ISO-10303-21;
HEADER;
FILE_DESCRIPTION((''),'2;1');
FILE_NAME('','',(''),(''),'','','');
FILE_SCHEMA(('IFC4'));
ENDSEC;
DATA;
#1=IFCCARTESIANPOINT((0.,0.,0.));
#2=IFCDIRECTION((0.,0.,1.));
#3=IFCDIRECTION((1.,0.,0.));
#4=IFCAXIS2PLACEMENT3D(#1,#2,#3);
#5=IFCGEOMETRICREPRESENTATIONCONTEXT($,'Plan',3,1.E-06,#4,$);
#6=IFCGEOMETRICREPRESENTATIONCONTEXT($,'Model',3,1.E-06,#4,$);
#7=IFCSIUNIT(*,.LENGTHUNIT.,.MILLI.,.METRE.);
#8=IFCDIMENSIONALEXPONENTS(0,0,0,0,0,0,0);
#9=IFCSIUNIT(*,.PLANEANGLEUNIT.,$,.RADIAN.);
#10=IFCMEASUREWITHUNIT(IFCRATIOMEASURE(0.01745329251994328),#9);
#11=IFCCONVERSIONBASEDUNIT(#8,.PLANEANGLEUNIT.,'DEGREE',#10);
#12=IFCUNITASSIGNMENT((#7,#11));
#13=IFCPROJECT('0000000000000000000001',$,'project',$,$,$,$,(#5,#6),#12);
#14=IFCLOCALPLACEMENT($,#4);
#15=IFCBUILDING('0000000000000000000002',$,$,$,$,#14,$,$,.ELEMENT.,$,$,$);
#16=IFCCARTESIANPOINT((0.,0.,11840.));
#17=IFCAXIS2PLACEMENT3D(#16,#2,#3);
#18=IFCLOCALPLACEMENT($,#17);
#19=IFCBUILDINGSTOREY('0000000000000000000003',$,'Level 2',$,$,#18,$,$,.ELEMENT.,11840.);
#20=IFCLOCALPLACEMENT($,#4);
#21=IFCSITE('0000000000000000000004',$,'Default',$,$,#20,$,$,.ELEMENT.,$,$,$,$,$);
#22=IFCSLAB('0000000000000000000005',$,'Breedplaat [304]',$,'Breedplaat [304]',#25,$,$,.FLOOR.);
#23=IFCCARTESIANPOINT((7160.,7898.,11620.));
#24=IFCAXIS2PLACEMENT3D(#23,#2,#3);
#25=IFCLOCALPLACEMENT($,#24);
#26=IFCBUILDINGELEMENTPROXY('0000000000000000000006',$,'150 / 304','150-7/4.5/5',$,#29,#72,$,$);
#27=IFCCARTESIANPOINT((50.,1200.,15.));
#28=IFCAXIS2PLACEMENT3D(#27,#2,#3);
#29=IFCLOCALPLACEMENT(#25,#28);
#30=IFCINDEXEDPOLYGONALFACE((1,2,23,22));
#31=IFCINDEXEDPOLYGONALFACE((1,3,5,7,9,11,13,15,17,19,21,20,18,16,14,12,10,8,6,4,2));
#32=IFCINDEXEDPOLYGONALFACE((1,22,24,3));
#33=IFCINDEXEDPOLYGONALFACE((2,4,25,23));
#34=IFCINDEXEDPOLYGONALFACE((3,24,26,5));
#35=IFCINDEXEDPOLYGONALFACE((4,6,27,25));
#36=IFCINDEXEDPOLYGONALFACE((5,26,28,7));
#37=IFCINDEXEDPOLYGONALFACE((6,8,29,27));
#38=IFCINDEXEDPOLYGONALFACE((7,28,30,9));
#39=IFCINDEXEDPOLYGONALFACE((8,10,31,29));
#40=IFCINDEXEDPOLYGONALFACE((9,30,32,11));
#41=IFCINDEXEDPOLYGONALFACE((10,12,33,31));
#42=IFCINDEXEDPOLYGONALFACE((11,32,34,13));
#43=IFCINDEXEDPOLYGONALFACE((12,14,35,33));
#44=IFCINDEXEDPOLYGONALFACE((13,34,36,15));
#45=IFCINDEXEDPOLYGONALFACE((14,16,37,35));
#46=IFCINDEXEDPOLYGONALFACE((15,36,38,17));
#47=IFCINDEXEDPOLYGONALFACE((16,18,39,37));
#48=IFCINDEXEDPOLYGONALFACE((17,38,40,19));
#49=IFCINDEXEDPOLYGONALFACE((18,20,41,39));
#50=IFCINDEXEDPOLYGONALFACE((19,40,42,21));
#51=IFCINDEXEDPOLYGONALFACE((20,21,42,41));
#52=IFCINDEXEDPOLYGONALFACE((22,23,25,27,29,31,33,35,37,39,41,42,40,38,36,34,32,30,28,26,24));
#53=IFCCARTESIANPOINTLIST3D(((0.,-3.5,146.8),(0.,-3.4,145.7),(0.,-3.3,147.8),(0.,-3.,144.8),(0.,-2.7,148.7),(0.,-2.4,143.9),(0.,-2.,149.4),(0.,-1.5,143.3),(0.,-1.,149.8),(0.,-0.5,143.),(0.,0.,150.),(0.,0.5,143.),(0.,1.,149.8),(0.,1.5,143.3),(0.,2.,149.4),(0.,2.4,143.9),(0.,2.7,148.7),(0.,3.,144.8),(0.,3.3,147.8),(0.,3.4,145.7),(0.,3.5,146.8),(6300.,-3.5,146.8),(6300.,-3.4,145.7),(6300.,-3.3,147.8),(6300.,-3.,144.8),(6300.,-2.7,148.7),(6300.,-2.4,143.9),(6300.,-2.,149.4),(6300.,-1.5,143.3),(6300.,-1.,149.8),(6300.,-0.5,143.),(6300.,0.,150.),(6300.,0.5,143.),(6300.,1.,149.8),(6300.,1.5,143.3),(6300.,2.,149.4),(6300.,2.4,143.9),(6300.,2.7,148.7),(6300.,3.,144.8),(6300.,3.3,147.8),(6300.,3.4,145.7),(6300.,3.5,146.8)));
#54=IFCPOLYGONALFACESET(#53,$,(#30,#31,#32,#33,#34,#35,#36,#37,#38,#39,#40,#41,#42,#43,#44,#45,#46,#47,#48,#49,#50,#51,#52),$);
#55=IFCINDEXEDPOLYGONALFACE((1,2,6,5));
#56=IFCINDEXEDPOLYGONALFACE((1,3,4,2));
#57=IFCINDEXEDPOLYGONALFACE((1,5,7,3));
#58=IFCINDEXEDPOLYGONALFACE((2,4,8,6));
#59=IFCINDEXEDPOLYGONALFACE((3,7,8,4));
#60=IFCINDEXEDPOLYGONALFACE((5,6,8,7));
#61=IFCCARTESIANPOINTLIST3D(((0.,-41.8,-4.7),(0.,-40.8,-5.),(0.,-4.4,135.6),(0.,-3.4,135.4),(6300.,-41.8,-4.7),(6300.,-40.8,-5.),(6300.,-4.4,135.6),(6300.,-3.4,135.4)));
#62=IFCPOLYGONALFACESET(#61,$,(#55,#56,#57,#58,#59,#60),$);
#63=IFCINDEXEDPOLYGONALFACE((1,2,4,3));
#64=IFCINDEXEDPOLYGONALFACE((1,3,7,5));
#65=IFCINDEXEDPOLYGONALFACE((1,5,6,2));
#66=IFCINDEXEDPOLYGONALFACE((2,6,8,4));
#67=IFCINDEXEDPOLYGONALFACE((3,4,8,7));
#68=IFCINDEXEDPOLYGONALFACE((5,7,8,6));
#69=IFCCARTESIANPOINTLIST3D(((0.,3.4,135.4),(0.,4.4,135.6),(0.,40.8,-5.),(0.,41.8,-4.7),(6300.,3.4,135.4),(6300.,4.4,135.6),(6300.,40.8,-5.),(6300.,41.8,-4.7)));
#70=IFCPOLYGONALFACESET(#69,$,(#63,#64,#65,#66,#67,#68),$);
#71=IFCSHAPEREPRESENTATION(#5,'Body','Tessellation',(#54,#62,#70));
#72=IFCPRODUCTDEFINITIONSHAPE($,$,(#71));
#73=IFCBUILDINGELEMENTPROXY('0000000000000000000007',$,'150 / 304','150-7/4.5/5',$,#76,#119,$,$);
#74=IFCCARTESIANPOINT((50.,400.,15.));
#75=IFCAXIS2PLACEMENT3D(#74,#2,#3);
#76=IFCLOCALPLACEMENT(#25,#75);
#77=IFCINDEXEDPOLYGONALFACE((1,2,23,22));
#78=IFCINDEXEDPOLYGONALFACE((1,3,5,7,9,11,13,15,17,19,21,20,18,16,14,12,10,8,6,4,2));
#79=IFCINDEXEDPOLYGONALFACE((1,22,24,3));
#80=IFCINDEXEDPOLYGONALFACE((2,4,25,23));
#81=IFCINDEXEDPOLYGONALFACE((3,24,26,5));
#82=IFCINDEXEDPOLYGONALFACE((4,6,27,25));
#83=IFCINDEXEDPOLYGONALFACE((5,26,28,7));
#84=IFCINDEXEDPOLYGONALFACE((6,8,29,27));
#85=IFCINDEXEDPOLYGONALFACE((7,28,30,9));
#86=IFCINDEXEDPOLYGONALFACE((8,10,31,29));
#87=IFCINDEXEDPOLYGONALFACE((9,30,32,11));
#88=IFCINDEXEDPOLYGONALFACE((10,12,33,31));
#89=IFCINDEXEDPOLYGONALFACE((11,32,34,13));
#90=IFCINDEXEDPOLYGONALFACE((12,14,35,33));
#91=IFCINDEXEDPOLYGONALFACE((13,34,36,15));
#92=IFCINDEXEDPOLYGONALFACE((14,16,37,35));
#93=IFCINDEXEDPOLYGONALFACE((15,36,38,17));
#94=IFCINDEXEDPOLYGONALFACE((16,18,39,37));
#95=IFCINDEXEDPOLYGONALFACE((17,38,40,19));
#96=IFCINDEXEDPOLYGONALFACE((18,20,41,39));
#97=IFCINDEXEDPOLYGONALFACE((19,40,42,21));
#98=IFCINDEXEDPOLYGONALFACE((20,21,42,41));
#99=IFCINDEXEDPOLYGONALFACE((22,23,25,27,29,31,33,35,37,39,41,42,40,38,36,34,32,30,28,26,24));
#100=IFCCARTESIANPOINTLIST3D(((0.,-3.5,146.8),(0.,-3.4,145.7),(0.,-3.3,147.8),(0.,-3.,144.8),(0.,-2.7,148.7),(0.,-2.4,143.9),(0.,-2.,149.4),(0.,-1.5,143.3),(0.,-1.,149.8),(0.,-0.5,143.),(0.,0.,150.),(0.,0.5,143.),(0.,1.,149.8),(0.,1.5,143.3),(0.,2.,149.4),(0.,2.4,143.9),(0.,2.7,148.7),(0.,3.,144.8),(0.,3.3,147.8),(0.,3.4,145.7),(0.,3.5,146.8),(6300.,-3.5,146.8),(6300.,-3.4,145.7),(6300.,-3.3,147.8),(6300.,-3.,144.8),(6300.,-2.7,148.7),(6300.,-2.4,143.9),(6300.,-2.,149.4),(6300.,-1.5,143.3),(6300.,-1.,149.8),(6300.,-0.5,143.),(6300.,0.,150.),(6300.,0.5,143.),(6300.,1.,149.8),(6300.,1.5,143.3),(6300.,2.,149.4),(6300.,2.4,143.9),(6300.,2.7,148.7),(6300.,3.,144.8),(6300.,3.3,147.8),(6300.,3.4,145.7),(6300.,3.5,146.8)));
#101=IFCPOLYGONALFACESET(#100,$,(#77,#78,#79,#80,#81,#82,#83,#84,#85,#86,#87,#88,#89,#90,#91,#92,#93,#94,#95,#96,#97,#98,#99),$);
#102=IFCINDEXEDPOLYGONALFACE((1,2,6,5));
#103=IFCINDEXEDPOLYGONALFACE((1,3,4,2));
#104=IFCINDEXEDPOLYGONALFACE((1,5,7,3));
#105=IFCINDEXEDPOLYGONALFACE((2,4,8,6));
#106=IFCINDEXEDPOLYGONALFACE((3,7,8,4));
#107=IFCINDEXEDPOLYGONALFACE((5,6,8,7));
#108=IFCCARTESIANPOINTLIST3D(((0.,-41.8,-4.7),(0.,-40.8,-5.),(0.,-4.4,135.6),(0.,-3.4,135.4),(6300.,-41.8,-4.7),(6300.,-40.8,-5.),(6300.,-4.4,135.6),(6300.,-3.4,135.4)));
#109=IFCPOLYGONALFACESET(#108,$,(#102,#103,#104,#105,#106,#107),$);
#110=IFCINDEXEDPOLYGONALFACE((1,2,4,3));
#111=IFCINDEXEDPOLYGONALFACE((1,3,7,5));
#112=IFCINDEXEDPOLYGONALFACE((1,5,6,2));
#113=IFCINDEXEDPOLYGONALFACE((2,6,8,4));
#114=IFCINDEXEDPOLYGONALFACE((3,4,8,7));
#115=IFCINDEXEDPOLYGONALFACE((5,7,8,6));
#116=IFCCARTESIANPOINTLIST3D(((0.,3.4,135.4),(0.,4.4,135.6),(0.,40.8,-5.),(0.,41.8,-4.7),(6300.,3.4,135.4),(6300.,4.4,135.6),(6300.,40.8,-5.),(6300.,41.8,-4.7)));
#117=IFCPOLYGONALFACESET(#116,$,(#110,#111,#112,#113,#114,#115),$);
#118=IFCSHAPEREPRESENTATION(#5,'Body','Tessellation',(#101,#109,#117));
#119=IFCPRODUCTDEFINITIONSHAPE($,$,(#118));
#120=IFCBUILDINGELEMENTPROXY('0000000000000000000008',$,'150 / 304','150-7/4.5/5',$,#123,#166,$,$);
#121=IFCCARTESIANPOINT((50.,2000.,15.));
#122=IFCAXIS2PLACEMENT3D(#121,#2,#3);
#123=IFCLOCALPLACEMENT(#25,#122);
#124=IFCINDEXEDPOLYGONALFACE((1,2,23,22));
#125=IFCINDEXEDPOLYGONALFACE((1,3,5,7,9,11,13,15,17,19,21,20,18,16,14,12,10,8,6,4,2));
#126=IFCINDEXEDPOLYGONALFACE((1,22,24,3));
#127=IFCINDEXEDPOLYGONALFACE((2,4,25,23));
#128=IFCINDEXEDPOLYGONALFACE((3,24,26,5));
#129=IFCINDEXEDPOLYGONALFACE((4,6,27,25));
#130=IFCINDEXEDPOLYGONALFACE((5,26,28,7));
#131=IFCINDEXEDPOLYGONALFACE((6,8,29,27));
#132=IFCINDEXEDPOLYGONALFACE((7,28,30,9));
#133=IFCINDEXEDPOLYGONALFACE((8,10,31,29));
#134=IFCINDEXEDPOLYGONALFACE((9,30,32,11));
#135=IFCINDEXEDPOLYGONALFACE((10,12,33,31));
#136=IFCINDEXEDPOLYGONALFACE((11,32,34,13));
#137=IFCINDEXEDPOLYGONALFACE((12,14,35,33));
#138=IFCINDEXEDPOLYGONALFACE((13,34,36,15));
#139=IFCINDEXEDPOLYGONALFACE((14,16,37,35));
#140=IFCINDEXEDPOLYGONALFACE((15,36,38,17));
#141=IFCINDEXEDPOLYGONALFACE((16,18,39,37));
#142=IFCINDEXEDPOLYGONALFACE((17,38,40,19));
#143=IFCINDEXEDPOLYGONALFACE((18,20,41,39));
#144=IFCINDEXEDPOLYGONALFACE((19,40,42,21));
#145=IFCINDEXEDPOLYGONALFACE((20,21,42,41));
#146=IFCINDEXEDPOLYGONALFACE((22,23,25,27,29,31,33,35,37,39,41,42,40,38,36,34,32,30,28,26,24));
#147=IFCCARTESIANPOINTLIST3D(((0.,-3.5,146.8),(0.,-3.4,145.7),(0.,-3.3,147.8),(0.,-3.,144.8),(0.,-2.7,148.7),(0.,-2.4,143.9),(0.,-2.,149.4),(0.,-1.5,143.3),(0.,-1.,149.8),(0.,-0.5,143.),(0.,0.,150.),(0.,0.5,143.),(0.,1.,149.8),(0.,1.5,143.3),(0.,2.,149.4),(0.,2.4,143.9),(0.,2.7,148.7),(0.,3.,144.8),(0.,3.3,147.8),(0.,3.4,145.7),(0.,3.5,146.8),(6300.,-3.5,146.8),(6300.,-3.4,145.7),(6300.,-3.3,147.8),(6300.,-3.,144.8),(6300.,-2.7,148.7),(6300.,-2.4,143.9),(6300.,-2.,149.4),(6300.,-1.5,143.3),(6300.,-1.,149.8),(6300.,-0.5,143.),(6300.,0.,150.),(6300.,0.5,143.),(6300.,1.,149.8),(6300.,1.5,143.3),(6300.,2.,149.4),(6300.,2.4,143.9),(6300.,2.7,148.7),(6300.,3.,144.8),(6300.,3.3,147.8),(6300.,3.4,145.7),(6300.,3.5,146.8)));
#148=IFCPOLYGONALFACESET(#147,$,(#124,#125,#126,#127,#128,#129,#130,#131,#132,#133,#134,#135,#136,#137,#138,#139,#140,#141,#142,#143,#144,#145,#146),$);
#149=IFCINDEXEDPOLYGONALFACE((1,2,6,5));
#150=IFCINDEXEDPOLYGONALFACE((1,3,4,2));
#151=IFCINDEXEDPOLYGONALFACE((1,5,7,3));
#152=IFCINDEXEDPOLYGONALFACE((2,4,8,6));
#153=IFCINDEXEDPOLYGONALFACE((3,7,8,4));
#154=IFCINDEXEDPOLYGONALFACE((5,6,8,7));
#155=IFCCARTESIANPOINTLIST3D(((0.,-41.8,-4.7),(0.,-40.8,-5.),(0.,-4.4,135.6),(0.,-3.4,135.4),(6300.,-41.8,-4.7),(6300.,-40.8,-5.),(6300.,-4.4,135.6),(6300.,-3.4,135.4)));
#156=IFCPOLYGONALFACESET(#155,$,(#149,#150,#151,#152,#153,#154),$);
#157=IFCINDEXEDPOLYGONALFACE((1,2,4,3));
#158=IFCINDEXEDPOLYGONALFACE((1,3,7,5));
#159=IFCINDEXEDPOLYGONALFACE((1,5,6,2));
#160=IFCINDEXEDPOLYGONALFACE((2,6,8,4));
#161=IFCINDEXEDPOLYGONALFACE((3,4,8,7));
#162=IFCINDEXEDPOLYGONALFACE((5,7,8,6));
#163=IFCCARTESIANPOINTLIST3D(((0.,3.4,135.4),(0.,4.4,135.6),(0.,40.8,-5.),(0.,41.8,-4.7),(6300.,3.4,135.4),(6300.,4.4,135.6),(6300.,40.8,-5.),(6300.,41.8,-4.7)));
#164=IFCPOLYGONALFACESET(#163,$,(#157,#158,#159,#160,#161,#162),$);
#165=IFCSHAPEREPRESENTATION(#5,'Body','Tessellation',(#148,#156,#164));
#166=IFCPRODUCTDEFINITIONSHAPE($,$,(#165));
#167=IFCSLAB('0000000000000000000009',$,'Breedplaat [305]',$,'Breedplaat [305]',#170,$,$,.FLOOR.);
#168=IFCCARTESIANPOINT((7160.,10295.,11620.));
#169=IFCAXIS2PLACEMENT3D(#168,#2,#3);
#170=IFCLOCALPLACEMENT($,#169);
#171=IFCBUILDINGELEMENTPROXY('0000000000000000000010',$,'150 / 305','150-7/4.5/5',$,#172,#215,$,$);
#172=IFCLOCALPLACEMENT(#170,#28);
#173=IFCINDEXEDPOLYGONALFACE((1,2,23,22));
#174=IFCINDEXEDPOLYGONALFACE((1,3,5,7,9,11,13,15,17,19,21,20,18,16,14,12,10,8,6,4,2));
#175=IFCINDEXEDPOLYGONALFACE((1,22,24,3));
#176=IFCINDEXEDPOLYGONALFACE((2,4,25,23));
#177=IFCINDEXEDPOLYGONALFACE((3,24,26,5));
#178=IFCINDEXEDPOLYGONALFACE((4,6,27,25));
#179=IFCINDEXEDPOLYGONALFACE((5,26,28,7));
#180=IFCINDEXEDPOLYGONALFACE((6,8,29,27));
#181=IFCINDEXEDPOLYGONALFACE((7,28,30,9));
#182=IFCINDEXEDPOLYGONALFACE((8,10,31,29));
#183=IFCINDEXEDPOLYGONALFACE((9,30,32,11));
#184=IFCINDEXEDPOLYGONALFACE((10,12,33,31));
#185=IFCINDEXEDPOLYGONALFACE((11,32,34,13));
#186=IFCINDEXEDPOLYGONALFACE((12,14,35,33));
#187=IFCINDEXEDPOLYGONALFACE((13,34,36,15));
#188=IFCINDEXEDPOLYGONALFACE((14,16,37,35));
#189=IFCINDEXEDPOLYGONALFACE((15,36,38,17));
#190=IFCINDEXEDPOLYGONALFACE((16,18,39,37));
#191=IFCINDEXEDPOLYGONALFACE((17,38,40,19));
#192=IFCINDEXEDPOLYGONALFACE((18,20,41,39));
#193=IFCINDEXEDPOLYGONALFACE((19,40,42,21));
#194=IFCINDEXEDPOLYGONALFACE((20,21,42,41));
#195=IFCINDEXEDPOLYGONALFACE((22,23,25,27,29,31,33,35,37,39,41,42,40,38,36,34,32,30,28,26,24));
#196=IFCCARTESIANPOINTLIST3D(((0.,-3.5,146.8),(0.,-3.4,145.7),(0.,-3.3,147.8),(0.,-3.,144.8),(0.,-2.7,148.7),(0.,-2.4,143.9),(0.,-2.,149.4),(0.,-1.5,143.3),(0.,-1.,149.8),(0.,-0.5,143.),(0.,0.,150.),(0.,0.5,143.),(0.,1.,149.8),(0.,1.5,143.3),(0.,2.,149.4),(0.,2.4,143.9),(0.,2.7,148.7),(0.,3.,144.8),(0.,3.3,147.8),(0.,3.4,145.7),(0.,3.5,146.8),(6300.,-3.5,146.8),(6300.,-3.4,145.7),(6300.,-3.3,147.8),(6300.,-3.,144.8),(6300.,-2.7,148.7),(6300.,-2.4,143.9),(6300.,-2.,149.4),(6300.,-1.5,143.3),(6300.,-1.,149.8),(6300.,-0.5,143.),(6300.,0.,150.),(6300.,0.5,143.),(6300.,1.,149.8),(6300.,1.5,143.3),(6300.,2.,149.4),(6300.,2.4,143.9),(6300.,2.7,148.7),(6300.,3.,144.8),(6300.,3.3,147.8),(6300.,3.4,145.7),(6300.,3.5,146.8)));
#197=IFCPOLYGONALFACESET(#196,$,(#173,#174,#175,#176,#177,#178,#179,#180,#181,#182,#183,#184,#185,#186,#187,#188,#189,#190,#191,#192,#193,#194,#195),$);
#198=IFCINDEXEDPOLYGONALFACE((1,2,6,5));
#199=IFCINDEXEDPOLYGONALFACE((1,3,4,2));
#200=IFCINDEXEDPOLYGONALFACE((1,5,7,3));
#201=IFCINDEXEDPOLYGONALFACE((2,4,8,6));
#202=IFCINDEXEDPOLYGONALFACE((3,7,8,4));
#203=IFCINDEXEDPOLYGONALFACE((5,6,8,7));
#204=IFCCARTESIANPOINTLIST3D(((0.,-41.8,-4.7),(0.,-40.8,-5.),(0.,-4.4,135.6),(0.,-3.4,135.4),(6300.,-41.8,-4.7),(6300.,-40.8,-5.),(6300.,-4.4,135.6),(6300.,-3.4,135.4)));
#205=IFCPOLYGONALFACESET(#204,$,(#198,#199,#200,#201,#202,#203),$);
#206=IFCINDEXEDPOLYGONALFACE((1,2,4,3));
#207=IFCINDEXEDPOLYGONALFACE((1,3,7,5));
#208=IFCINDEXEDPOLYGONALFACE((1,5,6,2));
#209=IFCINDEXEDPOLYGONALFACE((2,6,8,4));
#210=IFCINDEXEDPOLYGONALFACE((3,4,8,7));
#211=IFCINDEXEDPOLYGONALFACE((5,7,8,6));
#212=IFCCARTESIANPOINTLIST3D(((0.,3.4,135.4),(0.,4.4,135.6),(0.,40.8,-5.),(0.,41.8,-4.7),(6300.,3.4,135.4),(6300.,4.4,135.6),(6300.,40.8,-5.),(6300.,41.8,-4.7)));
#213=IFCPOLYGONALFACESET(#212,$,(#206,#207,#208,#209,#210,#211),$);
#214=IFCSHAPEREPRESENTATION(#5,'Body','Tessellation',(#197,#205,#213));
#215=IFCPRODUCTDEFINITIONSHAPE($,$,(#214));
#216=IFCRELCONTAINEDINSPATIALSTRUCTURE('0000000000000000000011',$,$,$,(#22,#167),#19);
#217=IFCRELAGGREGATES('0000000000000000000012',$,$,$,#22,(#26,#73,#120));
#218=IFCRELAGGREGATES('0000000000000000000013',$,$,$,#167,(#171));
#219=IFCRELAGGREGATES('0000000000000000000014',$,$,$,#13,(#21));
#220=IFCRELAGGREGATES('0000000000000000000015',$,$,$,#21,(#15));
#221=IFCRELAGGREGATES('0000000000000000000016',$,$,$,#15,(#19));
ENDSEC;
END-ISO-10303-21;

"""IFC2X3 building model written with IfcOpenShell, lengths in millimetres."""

from ifc_helpers import new_model, entity, si_unit, converted_unit, frame, origin_with_axes, origin_2d_with_axis, place, context, project, spatial, rectangle, circle, extrude, element, aggregate, save


model = new_model("IFC2X3")

# Units and contexts
plan_context = context("Plan", 3, precision=1e-06, world=origin_with_axes())
model_context = context("Model", 3, precision=1e-06, world=origin_with_axes())
ifc_project = project(units=[si_unit("LENGTHUNIT", "METRE", prefix="MILLI"), converted_unit("PLANEANGLEUNIT", "DEGREE", entity("IfcRatioMeasure", 0.01745329251994328), si_unit("PLANEANGLEUNIT", "RADIAN"), dimensions=[0, 0, 0, 0, 0, 0, 0])], contexts=[plan_context, model_context])

# Site, building, storey
site_placement = place(None, origin_with_axes())
site = spatial("IfcSite", under=ifc_project, at=site_placement, Name="Default", CompositionType="ELEMENT")
building_placement = place(None, origin_with_axes())
building = spatial("IfcBuilding", under=site, at=building_placement, CompositionType="ELEMENT")
storey_placement = place(None, frame((0.0, 0.0, 11840.0), z_axis=(0.0, 0.0, 1.0), x_axis=(1.0, 0.0, 0.0)))
storey = spatial("IfcBuildingStorey", under=building, at=storey_placement, Name="Level 2", CompositionType="ELEMENT", Elevation=11840.0)

# Slab, building element proxies
slab_1_placement = place(None, frame((7160.0, 7898.0, 11620.0), z_axis=(0.0, 0.0, 1.0), x_axis=(1.0, 0.0, 0.0)))
slab_1 = element("IfcSlab", 1, at=slab_1_placement, inside=storey, Name="Breedplaat [304]", ObjectType="Breedplaat [304]", PredefinedType="FLOOR")
proxy_1_placement = place(slab_1_placement, frame((50.0, 1200.0, 15.0), z_axis=(0.0, 0.0, 1.0), x_axis=(1.0, 0.0, 0.0)))
proxy_1 = element("IfcBuildingElementProxy", 2, at=proxy_1_placement, Name="150 / 304", Description="150-7/4.5/5", context=plan_context, shape_type="SweptSolid", body=[
    extrude(circle(Radius=3.5, at=origin_2d_with_axis()), frame((0.0, 0.0, 146.5), z_axis=(1.0, 0.0, 0.0), x_axis=(0.0, 0.0, 1.0)), (0.0, 0.0, 1.0), 6300.0),
    extrude(rectangle(XDim=145.2, YDim=1.0, at=origin_2d_with_axis()), frame((0.0, -22.6, 65.3), z_axis=(1.0, 0.0, 0.0), x_axis=(0.0, 0.257663, 0.966235)), (0.0, 0.0, 1.0), 6300.0),
    extrude(rectangle(XDim=145.2, YDim=1.0, at=origin_2d_with_axis()), frame((0.0, 22.6, 65.3), z_axis=(1.0, 0.0, 0.0), x_axis=(0.0, -0.257663, 0.966235)), (0.0, 0.0, 1.0), 6300.0),
])
proxy_2_placement = place(slab_1_placement, frame((50.0, 400.0, 15.0), z_axis=(0.0, 0.0, 1.0), x_axis=(1.0, 0.0, 0.0)))
proxy_2 = element("IfcBuildingElementProxy", 3, at=proxy_2_placement, Name="150 / 304", Description="150-7/4.5/5", context=plan_context, shape_type="SweptSolid", body=[
    extrude(circle(Radius=3.5, at=origin_2d_with_axis()), frame((0.0, 0.0, 146.5), z_axis=(1.0, 0.0, 0.0), x_axis=(0.0, 0.0, 1.0)), (0.0, 0.0, 1.0), 6300.0),
    extrude(rectangle(XDim=145.2, YDim=1.0, at=origin_2d_with_axis()), frame((0.0, -22.6, 65.3), z_axis=(1.0, 0.0, 0.0), x_axis=(0.0, 0.257663, 0.966235)), (0.0, 0.0, 1.0), 6300.0),
    extrude(rectangle(XDim=145.2, YDim=1.0, at=origin_2d_with_axis()), frame((0.0, 22.6, 65.3), z_axis=(1.0, 0.0, 0.0), x_axis=(0.0, -0.257663, 0.966235)), (0.0, 0.0, 1.0), 6300.0),
])
proxy_3_placement = place(slab_1_placement, frame((50.0, 2000.0, 15.0), z_axis=(0.0, 0.0, 1.0), x_axis=(1.0, 0.0, 0.0)))
proxy_3 = element("IfcBuildingElementProxy", 4, at=proxy_3_placement, Name="150 / 304", Description="150-7/4.5/5", context=plan_context, shape_type="SweptSolid", body=[
    extrude(circle(Radius=3.5, at=origin_2d_with_axis()), frame((0.0, 0.0, 146.5), z_axis=(1.0, 0.0, 0.0), x_axis=(0.0, 0.0, 1.0)), (0.0, 0.0, 1.0), 6300.0),
    extrude(rectangle(XDim=145.2, YDim=1.0, at=origin_2d_with_axis()), frame((0.0, -22.6, 65.3), z_axis=(1.0, 0.0, 0.0), x_axis=(0.0, 0.257663, 0.966235)), (0.0, 0.0, 1.0), 6300.0),
    extrude(rectangle(XDim=145.2, YDim=1.0, at=origin_2d_with_axis()), frame((0.0, 22.6, 65.3), z_axis=(1.0, 0.0, 0.0), x_axis=(0.0, -0.257663, 0.966235)), (0.0, 0.0, 1.0), 6300.0),
])
aggregate(slab_1, [proxy_1, proxy_2, proxy_3])

# Slab, building element proxy
slab_2_placement = place(None, frame((7160.0, 10295.0, 11620.0), z_axis=(0.0, 0.0, 1.0), x_axis=(1.0, 0.0, 0.0)))
slab_2 = element("IfcSlab", 5, at=slab_2_placement, inside=storey, Name="Breedplaat [305]", ObjectType="Breedplaat [305]", PredefinedType="FLOOR")
proxy_4_placement = place(slab_2_placement, frame((50.0, 1200.0, 15.0), z_axis=(0.0, 0.0, 1.0), x_axis=(1.0, 0.0, 0.0)))
proxy_4 = element("IfcBuildingElementProxy", 6, at=proxy_4_placement, Name="150 / 305", Description="150-7/4.5/5", context=plan_context, shape_type="SweptSolid", body=[
    extrude(circle(Radius=3.5, at=origin_2d_with_axis()), frame((0.0, 0.0, 146.5), z_axis=(1.0, 0.0, 0.0), x_axis=(0.0, 0.0, 1.0)), (0.0, 0.0, 1.0), 6300.0),
    extrude(rectangle(XDim=145.2, YDim=1.0, at=origin_2d_with_axis()), frame((0.0, -22.6, 65.3), z_axis=(1.0, 0.0, 0.0), x_axis=(0.0, 0.257663, 0.966235)), (0.0, 0.0, 1.0), 6300.0),
    extrude(rectangle(XDim=145.2, YDim=1.0, at=origin_2d_with_axis()), frame((0.0, 22.6, 65.3), z_axis=(1.0, 0.0, 0.0), x_axis=(0.0, -0.257663, 0.966235)), (0.0, 0.0, 1.0), 6300.0),
])
aggregate(slab_2, [proxy_4])

save(model, "model.ifc")
